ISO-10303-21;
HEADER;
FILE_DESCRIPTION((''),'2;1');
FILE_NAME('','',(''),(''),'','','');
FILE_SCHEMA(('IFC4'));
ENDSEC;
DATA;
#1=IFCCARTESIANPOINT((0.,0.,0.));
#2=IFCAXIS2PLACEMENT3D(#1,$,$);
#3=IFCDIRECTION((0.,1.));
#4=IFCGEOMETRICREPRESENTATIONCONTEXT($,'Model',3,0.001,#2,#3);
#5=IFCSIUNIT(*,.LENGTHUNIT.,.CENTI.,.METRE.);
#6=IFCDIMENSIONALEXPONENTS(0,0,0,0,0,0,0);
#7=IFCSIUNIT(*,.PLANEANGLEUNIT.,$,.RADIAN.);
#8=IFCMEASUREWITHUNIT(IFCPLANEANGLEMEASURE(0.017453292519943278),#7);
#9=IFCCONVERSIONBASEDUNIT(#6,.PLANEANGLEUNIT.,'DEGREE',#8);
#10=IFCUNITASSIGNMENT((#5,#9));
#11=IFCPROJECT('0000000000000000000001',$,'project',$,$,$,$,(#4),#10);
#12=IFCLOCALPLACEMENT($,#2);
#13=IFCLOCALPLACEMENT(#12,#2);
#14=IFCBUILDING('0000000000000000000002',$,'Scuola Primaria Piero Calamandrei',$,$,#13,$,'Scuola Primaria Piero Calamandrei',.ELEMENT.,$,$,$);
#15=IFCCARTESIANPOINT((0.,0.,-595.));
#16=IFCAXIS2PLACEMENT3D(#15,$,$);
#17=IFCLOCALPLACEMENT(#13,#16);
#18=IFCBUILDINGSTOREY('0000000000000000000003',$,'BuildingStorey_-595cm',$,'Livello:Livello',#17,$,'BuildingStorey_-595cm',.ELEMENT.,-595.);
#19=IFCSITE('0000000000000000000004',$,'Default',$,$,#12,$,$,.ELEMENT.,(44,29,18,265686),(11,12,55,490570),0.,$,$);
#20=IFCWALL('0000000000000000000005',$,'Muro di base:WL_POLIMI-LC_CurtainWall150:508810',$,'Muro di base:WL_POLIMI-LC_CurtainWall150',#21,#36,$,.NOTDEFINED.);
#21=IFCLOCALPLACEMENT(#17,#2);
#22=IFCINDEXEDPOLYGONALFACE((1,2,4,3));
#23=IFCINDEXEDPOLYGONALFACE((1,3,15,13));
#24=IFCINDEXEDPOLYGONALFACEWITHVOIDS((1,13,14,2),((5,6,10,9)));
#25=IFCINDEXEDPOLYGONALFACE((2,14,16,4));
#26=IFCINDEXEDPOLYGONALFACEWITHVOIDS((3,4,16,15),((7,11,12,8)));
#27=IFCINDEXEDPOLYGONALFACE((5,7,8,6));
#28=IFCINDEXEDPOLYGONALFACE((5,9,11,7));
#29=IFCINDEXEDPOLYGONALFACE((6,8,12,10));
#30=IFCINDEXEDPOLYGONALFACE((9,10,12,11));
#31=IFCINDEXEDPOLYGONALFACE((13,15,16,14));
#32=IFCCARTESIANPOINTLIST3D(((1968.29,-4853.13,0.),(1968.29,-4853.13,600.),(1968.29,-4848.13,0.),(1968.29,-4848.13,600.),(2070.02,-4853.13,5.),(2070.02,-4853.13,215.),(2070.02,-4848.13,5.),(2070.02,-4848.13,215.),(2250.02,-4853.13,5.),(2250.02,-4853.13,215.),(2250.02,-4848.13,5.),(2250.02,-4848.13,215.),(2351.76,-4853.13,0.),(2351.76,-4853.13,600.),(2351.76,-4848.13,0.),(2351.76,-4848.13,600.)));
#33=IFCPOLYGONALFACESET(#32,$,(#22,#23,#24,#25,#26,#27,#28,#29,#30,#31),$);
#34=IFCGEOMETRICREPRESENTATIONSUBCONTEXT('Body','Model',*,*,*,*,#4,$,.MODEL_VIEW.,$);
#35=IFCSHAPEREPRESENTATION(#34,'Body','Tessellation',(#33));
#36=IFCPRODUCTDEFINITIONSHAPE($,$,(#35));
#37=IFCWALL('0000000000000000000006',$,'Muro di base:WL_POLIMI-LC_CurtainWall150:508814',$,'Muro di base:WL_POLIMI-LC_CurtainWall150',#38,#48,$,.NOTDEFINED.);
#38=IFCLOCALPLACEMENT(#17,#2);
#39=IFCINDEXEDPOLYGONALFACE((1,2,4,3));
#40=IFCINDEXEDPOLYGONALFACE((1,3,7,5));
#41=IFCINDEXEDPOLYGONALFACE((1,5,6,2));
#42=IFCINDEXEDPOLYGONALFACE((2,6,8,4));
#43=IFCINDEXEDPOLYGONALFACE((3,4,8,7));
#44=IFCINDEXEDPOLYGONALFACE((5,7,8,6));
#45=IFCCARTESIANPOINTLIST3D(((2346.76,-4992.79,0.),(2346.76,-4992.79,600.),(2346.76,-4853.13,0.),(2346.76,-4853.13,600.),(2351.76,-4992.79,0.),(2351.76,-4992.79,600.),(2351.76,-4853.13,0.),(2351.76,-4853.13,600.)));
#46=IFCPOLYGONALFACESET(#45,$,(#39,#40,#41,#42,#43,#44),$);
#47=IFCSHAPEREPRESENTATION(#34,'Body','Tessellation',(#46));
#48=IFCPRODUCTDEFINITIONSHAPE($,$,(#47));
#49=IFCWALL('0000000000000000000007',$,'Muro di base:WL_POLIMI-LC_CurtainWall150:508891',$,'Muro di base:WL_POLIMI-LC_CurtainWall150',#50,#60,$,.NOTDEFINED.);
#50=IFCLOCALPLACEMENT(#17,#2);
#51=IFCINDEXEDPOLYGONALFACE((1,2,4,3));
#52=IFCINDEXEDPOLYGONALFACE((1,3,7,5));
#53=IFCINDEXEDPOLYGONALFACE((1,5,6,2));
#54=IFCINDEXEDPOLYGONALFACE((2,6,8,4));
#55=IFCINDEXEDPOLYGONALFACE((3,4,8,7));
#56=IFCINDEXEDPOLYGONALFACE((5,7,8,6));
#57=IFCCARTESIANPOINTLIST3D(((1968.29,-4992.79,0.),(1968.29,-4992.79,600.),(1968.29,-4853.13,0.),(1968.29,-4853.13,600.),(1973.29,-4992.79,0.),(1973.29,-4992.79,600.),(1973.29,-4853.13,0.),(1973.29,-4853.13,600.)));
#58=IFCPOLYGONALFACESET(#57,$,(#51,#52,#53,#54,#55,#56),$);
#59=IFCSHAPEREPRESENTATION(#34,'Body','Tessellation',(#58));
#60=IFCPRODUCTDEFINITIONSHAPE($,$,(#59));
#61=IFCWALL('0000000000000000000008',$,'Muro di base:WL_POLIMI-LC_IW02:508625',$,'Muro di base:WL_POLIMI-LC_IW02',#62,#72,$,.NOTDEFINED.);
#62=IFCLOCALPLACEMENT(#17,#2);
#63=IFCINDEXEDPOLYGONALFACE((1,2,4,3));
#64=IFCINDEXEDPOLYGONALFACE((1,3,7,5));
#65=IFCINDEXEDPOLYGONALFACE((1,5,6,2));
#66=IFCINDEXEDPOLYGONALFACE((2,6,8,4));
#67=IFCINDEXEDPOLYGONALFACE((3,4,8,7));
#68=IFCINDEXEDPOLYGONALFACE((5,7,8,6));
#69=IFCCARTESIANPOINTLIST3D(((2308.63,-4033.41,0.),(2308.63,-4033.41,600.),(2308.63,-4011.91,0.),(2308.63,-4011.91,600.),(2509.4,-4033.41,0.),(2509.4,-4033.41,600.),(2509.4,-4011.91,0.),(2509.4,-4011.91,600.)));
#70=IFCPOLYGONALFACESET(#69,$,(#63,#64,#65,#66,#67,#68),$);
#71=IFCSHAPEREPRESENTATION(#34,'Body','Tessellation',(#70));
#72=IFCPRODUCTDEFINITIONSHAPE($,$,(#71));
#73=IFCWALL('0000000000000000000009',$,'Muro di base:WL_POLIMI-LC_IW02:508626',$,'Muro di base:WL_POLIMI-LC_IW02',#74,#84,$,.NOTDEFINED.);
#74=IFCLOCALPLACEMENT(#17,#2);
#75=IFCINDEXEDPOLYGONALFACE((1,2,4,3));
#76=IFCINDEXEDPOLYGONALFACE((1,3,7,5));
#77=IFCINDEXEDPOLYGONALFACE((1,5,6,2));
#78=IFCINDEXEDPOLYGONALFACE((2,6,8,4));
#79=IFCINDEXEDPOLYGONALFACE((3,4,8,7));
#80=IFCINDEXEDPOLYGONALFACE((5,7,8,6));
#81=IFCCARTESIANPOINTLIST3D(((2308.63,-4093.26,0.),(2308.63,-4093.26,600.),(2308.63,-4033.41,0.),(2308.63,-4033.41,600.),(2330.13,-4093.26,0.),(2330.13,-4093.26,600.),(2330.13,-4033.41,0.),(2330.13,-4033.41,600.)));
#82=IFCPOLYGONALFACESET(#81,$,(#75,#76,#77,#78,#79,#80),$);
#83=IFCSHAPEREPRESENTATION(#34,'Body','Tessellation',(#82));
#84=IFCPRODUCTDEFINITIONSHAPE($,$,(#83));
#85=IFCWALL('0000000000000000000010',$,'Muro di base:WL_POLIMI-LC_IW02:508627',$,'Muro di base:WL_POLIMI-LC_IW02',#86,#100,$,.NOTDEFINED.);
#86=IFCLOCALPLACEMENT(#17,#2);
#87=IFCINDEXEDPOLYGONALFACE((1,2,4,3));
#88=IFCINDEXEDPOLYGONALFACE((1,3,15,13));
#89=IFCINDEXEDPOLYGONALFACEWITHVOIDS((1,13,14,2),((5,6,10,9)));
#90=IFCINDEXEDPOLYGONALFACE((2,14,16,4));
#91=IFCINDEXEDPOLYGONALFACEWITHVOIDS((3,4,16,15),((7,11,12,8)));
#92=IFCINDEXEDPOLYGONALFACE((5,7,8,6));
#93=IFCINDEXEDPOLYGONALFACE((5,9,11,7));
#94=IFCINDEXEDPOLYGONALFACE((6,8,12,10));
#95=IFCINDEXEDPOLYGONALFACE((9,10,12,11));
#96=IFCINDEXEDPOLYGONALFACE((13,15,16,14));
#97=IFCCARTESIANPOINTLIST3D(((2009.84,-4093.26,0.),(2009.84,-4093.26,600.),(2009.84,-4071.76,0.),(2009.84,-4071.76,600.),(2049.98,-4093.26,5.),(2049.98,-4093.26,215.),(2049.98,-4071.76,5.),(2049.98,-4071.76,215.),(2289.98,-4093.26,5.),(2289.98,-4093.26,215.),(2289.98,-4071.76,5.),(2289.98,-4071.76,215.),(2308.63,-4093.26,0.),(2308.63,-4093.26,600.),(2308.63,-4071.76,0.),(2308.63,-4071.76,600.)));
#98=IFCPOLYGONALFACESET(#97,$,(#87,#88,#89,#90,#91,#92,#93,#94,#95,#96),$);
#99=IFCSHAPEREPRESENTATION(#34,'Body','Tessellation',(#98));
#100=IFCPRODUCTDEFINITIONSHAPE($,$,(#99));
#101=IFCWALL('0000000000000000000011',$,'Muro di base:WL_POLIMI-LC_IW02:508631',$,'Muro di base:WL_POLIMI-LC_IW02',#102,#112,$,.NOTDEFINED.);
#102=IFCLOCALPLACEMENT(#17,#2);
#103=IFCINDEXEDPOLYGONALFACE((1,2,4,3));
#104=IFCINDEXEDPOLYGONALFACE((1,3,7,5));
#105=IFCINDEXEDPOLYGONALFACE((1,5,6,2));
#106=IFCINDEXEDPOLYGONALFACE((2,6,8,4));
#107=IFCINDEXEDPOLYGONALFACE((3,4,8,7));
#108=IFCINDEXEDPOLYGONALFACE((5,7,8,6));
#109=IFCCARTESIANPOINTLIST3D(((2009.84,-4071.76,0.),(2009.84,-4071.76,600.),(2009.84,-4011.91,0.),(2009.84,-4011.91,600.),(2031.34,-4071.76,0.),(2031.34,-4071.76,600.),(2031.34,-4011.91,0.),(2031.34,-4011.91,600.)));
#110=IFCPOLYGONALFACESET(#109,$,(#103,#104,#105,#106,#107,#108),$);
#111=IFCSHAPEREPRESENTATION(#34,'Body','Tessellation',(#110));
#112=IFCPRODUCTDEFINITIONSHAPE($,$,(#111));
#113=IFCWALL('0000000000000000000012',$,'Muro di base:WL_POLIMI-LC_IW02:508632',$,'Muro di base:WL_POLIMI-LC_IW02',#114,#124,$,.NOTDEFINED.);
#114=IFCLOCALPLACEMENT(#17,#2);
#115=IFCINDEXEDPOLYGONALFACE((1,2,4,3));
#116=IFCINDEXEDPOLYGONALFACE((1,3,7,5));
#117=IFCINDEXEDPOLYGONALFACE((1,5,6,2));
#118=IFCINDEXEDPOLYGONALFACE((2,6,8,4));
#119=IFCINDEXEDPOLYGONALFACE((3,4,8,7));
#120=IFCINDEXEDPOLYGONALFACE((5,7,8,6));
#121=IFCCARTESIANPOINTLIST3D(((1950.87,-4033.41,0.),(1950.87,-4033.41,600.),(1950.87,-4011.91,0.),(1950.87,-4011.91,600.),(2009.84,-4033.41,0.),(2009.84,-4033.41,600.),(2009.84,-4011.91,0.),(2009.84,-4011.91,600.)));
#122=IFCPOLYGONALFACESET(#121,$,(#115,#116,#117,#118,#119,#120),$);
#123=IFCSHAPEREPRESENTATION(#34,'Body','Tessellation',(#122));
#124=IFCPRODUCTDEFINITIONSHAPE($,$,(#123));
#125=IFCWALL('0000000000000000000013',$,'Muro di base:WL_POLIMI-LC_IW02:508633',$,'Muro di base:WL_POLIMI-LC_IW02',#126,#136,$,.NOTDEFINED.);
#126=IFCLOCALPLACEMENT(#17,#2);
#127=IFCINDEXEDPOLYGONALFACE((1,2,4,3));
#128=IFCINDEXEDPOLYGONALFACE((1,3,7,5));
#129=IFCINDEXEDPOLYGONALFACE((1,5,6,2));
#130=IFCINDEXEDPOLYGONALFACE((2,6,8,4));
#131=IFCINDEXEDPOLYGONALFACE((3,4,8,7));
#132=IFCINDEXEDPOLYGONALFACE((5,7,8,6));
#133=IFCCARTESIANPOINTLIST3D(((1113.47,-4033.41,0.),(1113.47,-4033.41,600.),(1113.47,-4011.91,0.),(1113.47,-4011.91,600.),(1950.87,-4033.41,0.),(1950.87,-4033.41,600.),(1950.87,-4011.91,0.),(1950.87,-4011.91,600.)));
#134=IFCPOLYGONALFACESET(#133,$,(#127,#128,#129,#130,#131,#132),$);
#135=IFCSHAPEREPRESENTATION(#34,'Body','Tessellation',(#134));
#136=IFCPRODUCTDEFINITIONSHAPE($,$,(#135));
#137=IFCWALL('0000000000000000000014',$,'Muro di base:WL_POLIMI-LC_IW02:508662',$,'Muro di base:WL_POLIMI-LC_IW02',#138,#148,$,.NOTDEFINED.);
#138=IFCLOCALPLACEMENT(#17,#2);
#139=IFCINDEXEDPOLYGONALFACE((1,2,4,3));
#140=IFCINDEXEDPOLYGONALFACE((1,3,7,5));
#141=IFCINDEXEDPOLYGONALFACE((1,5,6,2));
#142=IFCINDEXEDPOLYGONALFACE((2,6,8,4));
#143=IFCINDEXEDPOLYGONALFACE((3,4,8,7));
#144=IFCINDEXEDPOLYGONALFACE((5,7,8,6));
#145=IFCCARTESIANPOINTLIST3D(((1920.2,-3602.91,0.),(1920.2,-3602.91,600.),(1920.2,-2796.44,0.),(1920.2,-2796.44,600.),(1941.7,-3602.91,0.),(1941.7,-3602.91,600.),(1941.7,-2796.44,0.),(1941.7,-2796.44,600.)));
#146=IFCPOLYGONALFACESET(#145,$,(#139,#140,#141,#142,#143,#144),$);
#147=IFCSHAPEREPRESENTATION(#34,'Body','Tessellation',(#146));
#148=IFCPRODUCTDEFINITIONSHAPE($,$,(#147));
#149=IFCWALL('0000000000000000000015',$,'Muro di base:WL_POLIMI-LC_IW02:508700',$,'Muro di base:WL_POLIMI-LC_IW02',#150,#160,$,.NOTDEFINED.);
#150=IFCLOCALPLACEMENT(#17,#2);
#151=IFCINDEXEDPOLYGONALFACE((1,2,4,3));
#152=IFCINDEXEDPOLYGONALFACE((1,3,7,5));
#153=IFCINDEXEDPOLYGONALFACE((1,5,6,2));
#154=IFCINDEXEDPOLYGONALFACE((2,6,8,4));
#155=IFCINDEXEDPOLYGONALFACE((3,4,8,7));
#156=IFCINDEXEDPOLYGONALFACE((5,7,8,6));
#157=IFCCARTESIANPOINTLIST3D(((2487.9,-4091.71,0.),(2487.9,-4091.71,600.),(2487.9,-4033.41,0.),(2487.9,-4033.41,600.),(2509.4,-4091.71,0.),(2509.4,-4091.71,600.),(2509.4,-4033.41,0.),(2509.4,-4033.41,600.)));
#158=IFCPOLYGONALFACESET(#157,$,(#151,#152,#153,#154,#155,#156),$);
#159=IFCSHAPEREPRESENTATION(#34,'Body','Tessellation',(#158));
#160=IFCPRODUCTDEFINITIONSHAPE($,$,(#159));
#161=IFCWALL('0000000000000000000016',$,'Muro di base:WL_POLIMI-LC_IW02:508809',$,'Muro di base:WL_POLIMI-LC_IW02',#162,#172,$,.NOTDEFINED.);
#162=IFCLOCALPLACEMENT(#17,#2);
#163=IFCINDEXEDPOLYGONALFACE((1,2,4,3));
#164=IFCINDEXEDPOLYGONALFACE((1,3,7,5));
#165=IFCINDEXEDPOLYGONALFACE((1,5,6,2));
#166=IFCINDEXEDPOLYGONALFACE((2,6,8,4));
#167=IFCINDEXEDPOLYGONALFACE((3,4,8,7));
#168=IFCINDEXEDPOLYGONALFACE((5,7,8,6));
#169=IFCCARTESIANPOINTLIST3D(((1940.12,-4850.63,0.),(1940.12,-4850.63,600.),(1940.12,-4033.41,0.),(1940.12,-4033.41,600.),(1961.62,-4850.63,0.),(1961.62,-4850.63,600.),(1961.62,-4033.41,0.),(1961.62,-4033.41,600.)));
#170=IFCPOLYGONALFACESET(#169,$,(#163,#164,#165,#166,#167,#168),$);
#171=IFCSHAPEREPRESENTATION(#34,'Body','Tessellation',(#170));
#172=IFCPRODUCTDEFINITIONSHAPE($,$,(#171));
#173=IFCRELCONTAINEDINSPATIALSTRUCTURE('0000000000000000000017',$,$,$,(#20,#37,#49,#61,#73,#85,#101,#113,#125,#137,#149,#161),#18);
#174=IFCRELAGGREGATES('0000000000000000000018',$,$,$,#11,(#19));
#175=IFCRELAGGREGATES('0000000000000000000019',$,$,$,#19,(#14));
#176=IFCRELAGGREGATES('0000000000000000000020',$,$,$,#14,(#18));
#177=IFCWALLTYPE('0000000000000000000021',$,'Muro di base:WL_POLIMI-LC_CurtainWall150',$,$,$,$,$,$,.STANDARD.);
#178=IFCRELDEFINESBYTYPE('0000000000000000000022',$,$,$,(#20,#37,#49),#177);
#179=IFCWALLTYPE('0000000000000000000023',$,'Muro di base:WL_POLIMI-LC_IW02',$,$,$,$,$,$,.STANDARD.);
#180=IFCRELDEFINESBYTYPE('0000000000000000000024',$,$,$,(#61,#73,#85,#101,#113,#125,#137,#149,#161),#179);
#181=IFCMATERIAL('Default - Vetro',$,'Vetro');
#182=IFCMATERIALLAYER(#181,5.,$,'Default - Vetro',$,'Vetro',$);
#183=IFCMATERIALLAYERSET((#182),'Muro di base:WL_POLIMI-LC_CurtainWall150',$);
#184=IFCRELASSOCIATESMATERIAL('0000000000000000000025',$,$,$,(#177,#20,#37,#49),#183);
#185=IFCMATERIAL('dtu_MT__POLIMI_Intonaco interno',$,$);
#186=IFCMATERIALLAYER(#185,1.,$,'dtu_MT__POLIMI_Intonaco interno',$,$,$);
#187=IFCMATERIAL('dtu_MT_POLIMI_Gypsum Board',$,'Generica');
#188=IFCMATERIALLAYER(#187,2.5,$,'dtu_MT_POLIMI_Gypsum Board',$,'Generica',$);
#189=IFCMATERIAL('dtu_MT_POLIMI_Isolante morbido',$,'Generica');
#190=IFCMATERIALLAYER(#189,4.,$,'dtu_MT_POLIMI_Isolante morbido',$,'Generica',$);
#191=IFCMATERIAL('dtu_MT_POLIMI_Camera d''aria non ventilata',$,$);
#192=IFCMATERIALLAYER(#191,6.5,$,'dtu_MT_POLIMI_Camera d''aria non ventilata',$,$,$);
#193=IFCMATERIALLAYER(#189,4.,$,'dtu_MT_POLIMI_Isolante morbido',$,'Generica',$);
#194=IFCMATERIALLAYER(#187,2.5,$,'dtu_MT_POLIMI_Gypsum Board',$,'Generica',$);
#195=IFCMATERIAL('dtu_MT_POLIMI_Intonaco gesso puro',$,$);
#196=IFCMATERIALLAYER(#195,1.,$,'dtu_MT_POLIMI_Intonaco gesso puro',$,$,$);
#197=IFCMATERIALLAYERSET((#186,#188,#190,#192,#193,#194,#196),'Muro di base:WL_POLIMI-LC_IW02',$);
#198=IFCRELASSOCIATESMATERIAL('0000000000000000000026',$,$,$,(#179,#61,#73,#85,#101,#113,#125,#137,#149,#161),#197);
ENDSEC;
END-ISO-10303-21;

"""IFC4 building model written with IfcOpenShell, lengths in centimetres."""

from ifc_helpers import new_model, entity, si_unit, converted_unit, direction, frame, frame_2d, origin, place, context, subcontext, project, spatial, rectangle, extrude, material, layer, layer_set, layer_usage, type_object, element, save


model = new_model("IFC4")

# Units and contexts
model_context = context("Model", 3, precision=0.001, world=origin(), true_north=direction((0.0, 1.0)))
body_context = subcontext(model_context, "Body", "Model", "MODEL_VIEW")
ifc_project = project(units=[si_unit("LENGTHUNIT", "METRE", prefix="CENTI"), converted_unit("PLANEANGLEUNIT", "DEGREE", entity("IfcPlaneAngleMeasure", 0.017453292519943278), si_unit("PLANEANGLEUNIT", "RADIAN"), dimensions=[0, 0, 0, 0, 0, 0, 0])], contexts=[model_context])

# Site, building, storey
site_placement = place(None, origin())
site = spatial("IfcSite", under=ifc_project, at=site_placement, Name="Default", CompositionType="ELEMENT", RefLatitude=(44, 29, 18, 265686), RefLongitude=(11, 12, 55, 490570), RefElevation=0.0)
building_placement = place(site_placement, origin())
building = spatial("IfcBuilding", under=site, at=building_placement, Name="Scuola Primaria Piero Calamandrei", LongName="Scuola Primaria Piero Calamandrei", CompositionType="ELEMENT")
storey_placement = place(building_placement, frame((0.0, 0.0, -595.0)))
storey = spatial("IfcBuildingStorey", under=building, at=storey_placement, Name="BuildingStorey_-595cm", ObjectType="Livello:Livello", LongName="BuildingStorey_-595cm", CompositionType="ELEMENT", Elevation=-595.0)

# Wall, opening
ifc_material_1 = material(Name="Default - Vetro", Category="Vetro")
ifc_layer_1 = layer(ifc_material_1, 5.0, Name="Default - Vetro", Category="Vetro")
ifc_layer_set_1 = layer_set([ifc_layer_1], Name="Muro di base:WL_POLIMI-LC_CurtainWall150")
ifc_layer_usage_1 = layer_usage(ifc_layer_set_1, "AXIS2", "NEGATIVE", 2.5)
wall_type_1 = type_object("IfcWallType", Name="Muro di base:WL_POLIMI-LC_CurtainWall150", PredefinedType="STANDARD", material=ifc_layer_set_1)
wall_1_placement = place(storey_placement, frame((2351.76, -4850.63, 0.0), z_axis=(0.0, 0.0, 1.0), x_axis=(-1.0, 0.0, 0.0)))
wall_1 = element("IfcWall", 1, at=wall_1_placement, inside=storey, type_object=wall_type_1, material=ifc_layer_usage_1, Name="Muro di base:WL_POLIMI-LC_CurtainWall150:508810", ObjectType="Muro di base:WL_POLIMI-LC_CurtainWall150", PredefinedType="NOTDEFINED", context=body_context, shape_type="SweptSolid", body=[
    extrude(rectangle(XDim=383.47, YDim=5.0, at=frame_2d((191.73, 0.0), x_axis=(-1.0, 0.0))), origin(), (0.0, 0.0, 1.0), 600.0),
])
opening_1_placement = place(wall_1_placement, frame((101.73, -2.5, 5.0)))
element("IfcOpeningElement", 2, at=opening_1_placement, cuts=wall_1, PredefinedType="OPENING", context=body_context, shape_type="SweptSolid", body=[
    extrude(rectangle(XDim=210.0, YDim=180.0, at=frame_2d((105.0, 90.0), x_axis=(-1.0, 0.0))), frame((0.0, 0.0, 0.0), z_axis=(0.0, 1.0, 0.0), x_axis=(0.0, 0.0, 1.0)), (0.0, 0.0, 1.0), 5.0),
])

# Walls
ifc_layer_usage_2 = layer_usage(ifc_layer_set_1, "AXIS2", "NEGATIVE", 2.5)
wall_2_placement = place(storey_placement, frame((2349.26, -4992.79, 0.0), z_axis=(0.0, 0.0, 1.0), x_axis=(0.0, 1.0, 0.0)))
element("IfcWall", 3, at=wall_2_placement, inside=storey, type_object=wall_type_1, material=ifc_layer_usage_2, Name="Muro di base:WL_POLIMI-LC_CurtainWall150:508814", ObjectType="Muro di base:WL_POLIMI-LC_CurtainWall150", PredefinedType="NOTDEFINED", context=body_context, shape_type="SweptSolid", body=[
    extrude(rectangle(XDim=139.66, YDim=5.0, at=frame_2d((69.83, 0.0), x_axis=(-1.0, 0.0))), origin(), (0.0, 0.0, 1.0), 600.0),
])
ifc_layer_usage_3 = layer_usage(ifc_layer_set_1, "AXIS2", "NEGATIVE", 2.5)
wall_3_placement = place(storey_placement, frame((1970.79, -4992.79, 0.0), z_axis=(0.0, 0.0, 1.0), x_axis=(0.0, 1.0, 0.0)))
element("IfcWall", 4, at=wall_3_placement, inside=storey, type_object=wall_type_1, material=ifc_layer_usage_3, Name="Muro di base:WL_POLIMI-LC_CurtainWall150:508891", ObjectType="Muro di base:WL_POLIMI-LC_CurtainWall150", PredefinedType="NOTDEFINED", context=body_context, shape_type="SweptSolid", body=[
    extrude(rectangle(XDim=139.66, YDim=5.0, at=frame_2d((69.83, 0.0), x_axis=(-1.0, 0.0))), origin(), (0.0, 0.0, 1.0), 600.0),
])
ifc_material_2 = material(Name="dtu_MT__POLIMI_Intonaco interno")
ifc_layer_2 = layer(ifc_material_2, 1.0, Name="dtu_MT__POLIMI_Intonaco interno")
ifc_material_3 = material(Name="dtu_MT_POLIMI_Gypsum Board", Category="Generica")
ifc_layer_3 = layer(ifc_material_3, 2.5, Name="dtu_MT_POLIMI_Gypsum Board", Category="Generica")
ifc_material_4 = material(Name="dtu_MT_POLIMI_Isolante morbido", Category="Generica")
ifc_layer_4 = layer(ifc_material_4, 4.0, Name="dtu_MT_POLIMI_Isolante morbido", Category="Generica")
ifc_material_5 = material(Name="dtu_MT_POLIMI_Camera d'aria non ventilata")
ifc_layer_5 = layer(ifc_material_5, 6.5, Name="dtu_MT_POLIMI_Camera d'aria non ventilata")
ifc_layer_6 = layer(ifc_material_4, 4.0, Name="dtu_MT_POLIMI_Isolante morbido", Category="Generica")
ifc_layer_7 = layer(ifc_material_3, 2.5, Name="dtu_MT_POLIMI_Gypsum Board", Category="Generica")
ifc_material_6 = material(Name="dtu_MT_POLIMI_Intonaco gesso puro")
ifc_layer_8 = layer(ifc_material_6, 1.0, Name="dtu_MT_POLIMI_Intonaco gesso puro")
ifc_layer_set_2 = layer_set([ifc_layer_2, ifc_layer_3, ifc_layer_4, ifc_layer_5, ifc_layer_6, ifc_layer_7, ifc_layer_8], Name="Muro di base:WL_POLIMI-LC_IW02")
ifc_layer_usage_4 = layer_usage(ifc_layer_set_2, "AXIS2", "NEGATIVE", 10.75)
wall_type_2 = type_object("IfcWallType", Name="Muro di base:WL_POLIMI-LC_IW02", PredefinedType="STANDARD", material=ifc_layer_set_2)
wall_4_placement = place(storey_placement, frame((2509.4, -4022.66, 0.0), z_axis=(0.0, 0.0, 1.0), x_axis=(-1.0, 0.0, 0.0)))
element("IfcWall", 5, at=wall_4_placement, inside=storey, type_object=wall_type_2, material=ifc_layer_usage_4, Name="Muro di base:WL_POLIMI-LC_IW02:508625", ObjectType="Muro di base:WL_POLIMI-LC_IW02", PredefinedType="NOTDEFINED", context=body_context, shape_type="SweptSolid", body=[
    extrude(rectangle(XDim=200.77, YDim=21.5, at=frame_2d((100.39, 0.0), x_axis=(-1.0, 0.0))), origin(), (0.0, 0.0, 1.0), 600.0),
])
ifc_layer_usage_5 = layer_usage(ifc_layer_set_2, "AXIS2", "NEGATIVE", 10.75)
wall_5_placement = place(storey_placement, frame((2319.38, -4033.41, 0.0), z_axis=(0.0, 0.0, 1.0), x_axis=(0.0, -1.0, 0.0)))
element("IfcWall", 6, at=wall_5_placement, inside=storey, type_object=wall_type_2, material=ifc_layer_usage_5, Name="Muro di base:WL_POLIMI-LC_IW02:508626", ObjectType="Muro di base:WL_POLIMI-LC_IW02", PredefinedType="NOTDEFINED", context=body_context, shape_type="SweptSolid", body=[
    extrude(rectangle(XDim=59.85, YDim=21.5, at=frame_2d((29.93, 0.0), x_axis=(-1.0, 0.0))), origin(), (0.0, 0.0, 1.0), 600.0),
])

# Wall, opening
ifc_layer_usage_6 = layer_usage(ifc_layer_set_2, "AXIS2", "NEGATIVE", 10.75)
wall_6_placement = place(storey_placement, frame((2308.63, -4082.51, 0.0), z_axis=(0.0, 0.0, 1.0), x_axis=(-1.0, 0.0, 0.0)))
wall_6 = element("IfcWall", 7, at=wall_6_placement, inside=storey, type_object=wall_type_2, material=ifc_layer_usage_6, Name="Muro di base:WL_POLIMI-LC_IW02:508627", ObjectType="Muro di base:WL_POLIMI-LC_IW02", PredefinedType="NOTDEFINED", context=body_context, shape_type="SweptSolid", body=[
    extrude(rectangle(XDim=298.79, YDim=21.5, at=frame_2d((149.39, 0.0), x_axis=(-1.0, 0.0))), origin(), (0.0, 0.0, 1.0), 600.0),
])
opening_2_placement = place(wall_6_placement, frame((258.64, 10.75, 5.0)))
element("IfcOpeningElement", 8, at=opening_2_placement, cuts=wall_6, PredefinedType="OPENING", context=body_context, shape_type="SweptSolid", body=[
    extrude(rectangle(XDim=210.0, YDim=240.0, at=frame_2d((105.0, 120.0), x_axis=(-1.0, 0.0))), frame((0.0, 0.0, 0.0), z_axis=(0.0, -1.0, 0.0), x_axis=(0.0, 0.0, 1.0)), (0.0, 0.0, 1.0), 21.5),
])

# Walls
ifc_layer_usage_7 = layer_usage(ifc_layer_set_2, "AXIS2", "NEGATIVE", 10.75)
wall_7_placement = place(storey_placement, frame((2020.59, -4071.76, 0.0), z_axis=(0.0, 0.0, 1.0), x_axis=(0.0, 1.0, 0.0)))
element("IfcWall", 9, at=wall_7_placement, inside=storey, type_object=wall_type_2, material=ifc_layer_usage_7, Name="Muro di base:WL_POLIMI-LC_IW02:508631", ObjectType="Muro di base:WL_POLIMI-LC_IW02", PredefinedType="NOTDEFINED", context=body_context, shape_type="SweptSolid", body=[
    extrude(rectangle(XDim=59.85, YDim=21.5, at=frame_2d((29.93, 0.0), x_axis=(-1.0, 0.0))), origin(), (0.0, 0.0, 1.0), 600.0),
])
ifc_layer_usage_8 = layer_usage(ifc_layer_set_2, "AXIS2", "NEGATIVE", 10.75)
wall_8_placement = place(storey_placement, frame((2009.84, -4022.66, 0.0), z_axis=(0.0, 0.0, 1.0), x_axis=(-1.0, 0.0, 0.0)))
element("IfcWall", 10, at=wall_8_placement, inside=storey, type_object=wall_type_2, material=ifc_layer_usage_8, Name="Muro di base:WL_POLIMI-LC_IW02:508632", ObjectType="Muro di base:WL_POLIMI-LC_IW02", PredefinedType="NOTDEFINED", context=body_context, shape_type="SweptSolid", body=[
    extrude(rectangle(XDim=58.97, YDim=21.5, at=frame_2d((29.48, 0.0), x_axis=(-1.0, 0.0))), origin(), (0.0, 0.0, 1.0), 600.0),
])
ifc_layer_usage_9 = layer_usage(ifc_layer_set_2, "AXIS2", "NEGATIVE", 10.75)
wall_9_placement = place(storey_placement, frame((1950.87, -4022.66, 0.0), z_axis=(0.0, 0.0, 1.0), x_axis=(-1.0, 0.0, 0.0)))
element("IfcWall", 11, at=wall_9_placement, inside=storey, type_object=wall_type_2, material=ifc_layer_usage_9, Name="Muro di base:WL_POLIMI-LC_IW02:508633", ObjectType="Muro di base:WL_POLIMI-LC_IW02", PredefinedType="NOTDEFINED", context=body_context, shape_type="SweptSolid", body=[
    extrude(rectangle(XDim=837.4, YDim=21.5, at=frame_2d((418.7, 0.0), x_axis=(-1.0, 0.0))), origin(), (0.0, 0.0, 1.0), 600.0),
])
ifc_layer_usage_10 = layer_usage(ifc_layer_set_2, "AXIS2", "NEGATIVE", 10.75)
wall_10_placement = place(storey_placement, frame((1930.95, -3602.91, 0.0), z_axis=(0.0, 0.0, 1.0), x_axis=(0.0, 1.0, 0.0)))
element("IfcWall", 12, at=wall_10_placement, inside=storey, type_object=wall_type_2, material=ifc_layer_usage_10, Name="Muro di base:WL_POLIMI-LC_IW02:508662", ObjectType="Muro di base:WL_POLIMI-LC_IW02", PredefinedType="NOTDEFINED", context=body_context, shape_type="SweptSolid", body=[
    extrude(rectangle(XDim=806.47, YDim=21.5, at=frame_2d((403.24, 0.0), x_axis=(-1.0, 0.0))), origin(), (0.0, 0.0, 1.0), 600.0),
])
ifc_layer_usage_11 = layer_usage(ifc_layer_set_2, "AXIS2", "NEGATIVE", 10.75)
wall_11_placement = place(storey_placement, frame((2498.65, -4091.71, 0.0), z_axis=(0.0, 0.0, 1.0), x_axis=(0.0, 1.0, 0.0)))
element("IfcWall", 13, at=wall_11_placement, inside=storey, type_object=wall_type_2, material=ifc_layer_usage_11, Name="Muro di base:WL_POLIMI-LC_IW02:508700", ObjectType="Muro di base:WL_POLIMI-LC_IW02", PredefinedType="NOTDEFINED", context=body_context, shape_type="SweptSolid", body=[
    extrude(rectangle(XDim=58.3, YDim=21.5, at=frame_2d((29.15, 0.0), x_axis=(-1.0, 0.0))), origin(), (0.0, 0.0, 1.0), 600.0),
])
ifc_layer_usage_12 = layer_usage(ifc_layer_set_2, "AXIS2", "NEGATIVE", 10.75)
wall_12_placement = place(storey_placement, frame((1950.87, -4850.63, 0.0), z_axis=(0.0, 0.0, 1.0), x_axis=(0.0, 1.0, 0.0)))
element("IfcWall", 14, at=wall_12_placement, inside=storey, type_object=wall_type_2, material=ifc_layer_usage_12, Name="Muro di base:WL_POLIMI-LC_IW02:508809", ObjectType="Muro di base:WL_POLIMI-LC_IW02", PredefinedType="NOTDEFINED", context=body_context, shape_type="SweptSolid", body=[
    extrude(rectangle(XDim=817.22, YDim=21.5, at=frame_2d((408.61, 0.0), x_axis=(-1.0, 0.0))), origin(), (0.0, 0.0, 1.0), 600.0),
])

save(model, "model.ifc")
